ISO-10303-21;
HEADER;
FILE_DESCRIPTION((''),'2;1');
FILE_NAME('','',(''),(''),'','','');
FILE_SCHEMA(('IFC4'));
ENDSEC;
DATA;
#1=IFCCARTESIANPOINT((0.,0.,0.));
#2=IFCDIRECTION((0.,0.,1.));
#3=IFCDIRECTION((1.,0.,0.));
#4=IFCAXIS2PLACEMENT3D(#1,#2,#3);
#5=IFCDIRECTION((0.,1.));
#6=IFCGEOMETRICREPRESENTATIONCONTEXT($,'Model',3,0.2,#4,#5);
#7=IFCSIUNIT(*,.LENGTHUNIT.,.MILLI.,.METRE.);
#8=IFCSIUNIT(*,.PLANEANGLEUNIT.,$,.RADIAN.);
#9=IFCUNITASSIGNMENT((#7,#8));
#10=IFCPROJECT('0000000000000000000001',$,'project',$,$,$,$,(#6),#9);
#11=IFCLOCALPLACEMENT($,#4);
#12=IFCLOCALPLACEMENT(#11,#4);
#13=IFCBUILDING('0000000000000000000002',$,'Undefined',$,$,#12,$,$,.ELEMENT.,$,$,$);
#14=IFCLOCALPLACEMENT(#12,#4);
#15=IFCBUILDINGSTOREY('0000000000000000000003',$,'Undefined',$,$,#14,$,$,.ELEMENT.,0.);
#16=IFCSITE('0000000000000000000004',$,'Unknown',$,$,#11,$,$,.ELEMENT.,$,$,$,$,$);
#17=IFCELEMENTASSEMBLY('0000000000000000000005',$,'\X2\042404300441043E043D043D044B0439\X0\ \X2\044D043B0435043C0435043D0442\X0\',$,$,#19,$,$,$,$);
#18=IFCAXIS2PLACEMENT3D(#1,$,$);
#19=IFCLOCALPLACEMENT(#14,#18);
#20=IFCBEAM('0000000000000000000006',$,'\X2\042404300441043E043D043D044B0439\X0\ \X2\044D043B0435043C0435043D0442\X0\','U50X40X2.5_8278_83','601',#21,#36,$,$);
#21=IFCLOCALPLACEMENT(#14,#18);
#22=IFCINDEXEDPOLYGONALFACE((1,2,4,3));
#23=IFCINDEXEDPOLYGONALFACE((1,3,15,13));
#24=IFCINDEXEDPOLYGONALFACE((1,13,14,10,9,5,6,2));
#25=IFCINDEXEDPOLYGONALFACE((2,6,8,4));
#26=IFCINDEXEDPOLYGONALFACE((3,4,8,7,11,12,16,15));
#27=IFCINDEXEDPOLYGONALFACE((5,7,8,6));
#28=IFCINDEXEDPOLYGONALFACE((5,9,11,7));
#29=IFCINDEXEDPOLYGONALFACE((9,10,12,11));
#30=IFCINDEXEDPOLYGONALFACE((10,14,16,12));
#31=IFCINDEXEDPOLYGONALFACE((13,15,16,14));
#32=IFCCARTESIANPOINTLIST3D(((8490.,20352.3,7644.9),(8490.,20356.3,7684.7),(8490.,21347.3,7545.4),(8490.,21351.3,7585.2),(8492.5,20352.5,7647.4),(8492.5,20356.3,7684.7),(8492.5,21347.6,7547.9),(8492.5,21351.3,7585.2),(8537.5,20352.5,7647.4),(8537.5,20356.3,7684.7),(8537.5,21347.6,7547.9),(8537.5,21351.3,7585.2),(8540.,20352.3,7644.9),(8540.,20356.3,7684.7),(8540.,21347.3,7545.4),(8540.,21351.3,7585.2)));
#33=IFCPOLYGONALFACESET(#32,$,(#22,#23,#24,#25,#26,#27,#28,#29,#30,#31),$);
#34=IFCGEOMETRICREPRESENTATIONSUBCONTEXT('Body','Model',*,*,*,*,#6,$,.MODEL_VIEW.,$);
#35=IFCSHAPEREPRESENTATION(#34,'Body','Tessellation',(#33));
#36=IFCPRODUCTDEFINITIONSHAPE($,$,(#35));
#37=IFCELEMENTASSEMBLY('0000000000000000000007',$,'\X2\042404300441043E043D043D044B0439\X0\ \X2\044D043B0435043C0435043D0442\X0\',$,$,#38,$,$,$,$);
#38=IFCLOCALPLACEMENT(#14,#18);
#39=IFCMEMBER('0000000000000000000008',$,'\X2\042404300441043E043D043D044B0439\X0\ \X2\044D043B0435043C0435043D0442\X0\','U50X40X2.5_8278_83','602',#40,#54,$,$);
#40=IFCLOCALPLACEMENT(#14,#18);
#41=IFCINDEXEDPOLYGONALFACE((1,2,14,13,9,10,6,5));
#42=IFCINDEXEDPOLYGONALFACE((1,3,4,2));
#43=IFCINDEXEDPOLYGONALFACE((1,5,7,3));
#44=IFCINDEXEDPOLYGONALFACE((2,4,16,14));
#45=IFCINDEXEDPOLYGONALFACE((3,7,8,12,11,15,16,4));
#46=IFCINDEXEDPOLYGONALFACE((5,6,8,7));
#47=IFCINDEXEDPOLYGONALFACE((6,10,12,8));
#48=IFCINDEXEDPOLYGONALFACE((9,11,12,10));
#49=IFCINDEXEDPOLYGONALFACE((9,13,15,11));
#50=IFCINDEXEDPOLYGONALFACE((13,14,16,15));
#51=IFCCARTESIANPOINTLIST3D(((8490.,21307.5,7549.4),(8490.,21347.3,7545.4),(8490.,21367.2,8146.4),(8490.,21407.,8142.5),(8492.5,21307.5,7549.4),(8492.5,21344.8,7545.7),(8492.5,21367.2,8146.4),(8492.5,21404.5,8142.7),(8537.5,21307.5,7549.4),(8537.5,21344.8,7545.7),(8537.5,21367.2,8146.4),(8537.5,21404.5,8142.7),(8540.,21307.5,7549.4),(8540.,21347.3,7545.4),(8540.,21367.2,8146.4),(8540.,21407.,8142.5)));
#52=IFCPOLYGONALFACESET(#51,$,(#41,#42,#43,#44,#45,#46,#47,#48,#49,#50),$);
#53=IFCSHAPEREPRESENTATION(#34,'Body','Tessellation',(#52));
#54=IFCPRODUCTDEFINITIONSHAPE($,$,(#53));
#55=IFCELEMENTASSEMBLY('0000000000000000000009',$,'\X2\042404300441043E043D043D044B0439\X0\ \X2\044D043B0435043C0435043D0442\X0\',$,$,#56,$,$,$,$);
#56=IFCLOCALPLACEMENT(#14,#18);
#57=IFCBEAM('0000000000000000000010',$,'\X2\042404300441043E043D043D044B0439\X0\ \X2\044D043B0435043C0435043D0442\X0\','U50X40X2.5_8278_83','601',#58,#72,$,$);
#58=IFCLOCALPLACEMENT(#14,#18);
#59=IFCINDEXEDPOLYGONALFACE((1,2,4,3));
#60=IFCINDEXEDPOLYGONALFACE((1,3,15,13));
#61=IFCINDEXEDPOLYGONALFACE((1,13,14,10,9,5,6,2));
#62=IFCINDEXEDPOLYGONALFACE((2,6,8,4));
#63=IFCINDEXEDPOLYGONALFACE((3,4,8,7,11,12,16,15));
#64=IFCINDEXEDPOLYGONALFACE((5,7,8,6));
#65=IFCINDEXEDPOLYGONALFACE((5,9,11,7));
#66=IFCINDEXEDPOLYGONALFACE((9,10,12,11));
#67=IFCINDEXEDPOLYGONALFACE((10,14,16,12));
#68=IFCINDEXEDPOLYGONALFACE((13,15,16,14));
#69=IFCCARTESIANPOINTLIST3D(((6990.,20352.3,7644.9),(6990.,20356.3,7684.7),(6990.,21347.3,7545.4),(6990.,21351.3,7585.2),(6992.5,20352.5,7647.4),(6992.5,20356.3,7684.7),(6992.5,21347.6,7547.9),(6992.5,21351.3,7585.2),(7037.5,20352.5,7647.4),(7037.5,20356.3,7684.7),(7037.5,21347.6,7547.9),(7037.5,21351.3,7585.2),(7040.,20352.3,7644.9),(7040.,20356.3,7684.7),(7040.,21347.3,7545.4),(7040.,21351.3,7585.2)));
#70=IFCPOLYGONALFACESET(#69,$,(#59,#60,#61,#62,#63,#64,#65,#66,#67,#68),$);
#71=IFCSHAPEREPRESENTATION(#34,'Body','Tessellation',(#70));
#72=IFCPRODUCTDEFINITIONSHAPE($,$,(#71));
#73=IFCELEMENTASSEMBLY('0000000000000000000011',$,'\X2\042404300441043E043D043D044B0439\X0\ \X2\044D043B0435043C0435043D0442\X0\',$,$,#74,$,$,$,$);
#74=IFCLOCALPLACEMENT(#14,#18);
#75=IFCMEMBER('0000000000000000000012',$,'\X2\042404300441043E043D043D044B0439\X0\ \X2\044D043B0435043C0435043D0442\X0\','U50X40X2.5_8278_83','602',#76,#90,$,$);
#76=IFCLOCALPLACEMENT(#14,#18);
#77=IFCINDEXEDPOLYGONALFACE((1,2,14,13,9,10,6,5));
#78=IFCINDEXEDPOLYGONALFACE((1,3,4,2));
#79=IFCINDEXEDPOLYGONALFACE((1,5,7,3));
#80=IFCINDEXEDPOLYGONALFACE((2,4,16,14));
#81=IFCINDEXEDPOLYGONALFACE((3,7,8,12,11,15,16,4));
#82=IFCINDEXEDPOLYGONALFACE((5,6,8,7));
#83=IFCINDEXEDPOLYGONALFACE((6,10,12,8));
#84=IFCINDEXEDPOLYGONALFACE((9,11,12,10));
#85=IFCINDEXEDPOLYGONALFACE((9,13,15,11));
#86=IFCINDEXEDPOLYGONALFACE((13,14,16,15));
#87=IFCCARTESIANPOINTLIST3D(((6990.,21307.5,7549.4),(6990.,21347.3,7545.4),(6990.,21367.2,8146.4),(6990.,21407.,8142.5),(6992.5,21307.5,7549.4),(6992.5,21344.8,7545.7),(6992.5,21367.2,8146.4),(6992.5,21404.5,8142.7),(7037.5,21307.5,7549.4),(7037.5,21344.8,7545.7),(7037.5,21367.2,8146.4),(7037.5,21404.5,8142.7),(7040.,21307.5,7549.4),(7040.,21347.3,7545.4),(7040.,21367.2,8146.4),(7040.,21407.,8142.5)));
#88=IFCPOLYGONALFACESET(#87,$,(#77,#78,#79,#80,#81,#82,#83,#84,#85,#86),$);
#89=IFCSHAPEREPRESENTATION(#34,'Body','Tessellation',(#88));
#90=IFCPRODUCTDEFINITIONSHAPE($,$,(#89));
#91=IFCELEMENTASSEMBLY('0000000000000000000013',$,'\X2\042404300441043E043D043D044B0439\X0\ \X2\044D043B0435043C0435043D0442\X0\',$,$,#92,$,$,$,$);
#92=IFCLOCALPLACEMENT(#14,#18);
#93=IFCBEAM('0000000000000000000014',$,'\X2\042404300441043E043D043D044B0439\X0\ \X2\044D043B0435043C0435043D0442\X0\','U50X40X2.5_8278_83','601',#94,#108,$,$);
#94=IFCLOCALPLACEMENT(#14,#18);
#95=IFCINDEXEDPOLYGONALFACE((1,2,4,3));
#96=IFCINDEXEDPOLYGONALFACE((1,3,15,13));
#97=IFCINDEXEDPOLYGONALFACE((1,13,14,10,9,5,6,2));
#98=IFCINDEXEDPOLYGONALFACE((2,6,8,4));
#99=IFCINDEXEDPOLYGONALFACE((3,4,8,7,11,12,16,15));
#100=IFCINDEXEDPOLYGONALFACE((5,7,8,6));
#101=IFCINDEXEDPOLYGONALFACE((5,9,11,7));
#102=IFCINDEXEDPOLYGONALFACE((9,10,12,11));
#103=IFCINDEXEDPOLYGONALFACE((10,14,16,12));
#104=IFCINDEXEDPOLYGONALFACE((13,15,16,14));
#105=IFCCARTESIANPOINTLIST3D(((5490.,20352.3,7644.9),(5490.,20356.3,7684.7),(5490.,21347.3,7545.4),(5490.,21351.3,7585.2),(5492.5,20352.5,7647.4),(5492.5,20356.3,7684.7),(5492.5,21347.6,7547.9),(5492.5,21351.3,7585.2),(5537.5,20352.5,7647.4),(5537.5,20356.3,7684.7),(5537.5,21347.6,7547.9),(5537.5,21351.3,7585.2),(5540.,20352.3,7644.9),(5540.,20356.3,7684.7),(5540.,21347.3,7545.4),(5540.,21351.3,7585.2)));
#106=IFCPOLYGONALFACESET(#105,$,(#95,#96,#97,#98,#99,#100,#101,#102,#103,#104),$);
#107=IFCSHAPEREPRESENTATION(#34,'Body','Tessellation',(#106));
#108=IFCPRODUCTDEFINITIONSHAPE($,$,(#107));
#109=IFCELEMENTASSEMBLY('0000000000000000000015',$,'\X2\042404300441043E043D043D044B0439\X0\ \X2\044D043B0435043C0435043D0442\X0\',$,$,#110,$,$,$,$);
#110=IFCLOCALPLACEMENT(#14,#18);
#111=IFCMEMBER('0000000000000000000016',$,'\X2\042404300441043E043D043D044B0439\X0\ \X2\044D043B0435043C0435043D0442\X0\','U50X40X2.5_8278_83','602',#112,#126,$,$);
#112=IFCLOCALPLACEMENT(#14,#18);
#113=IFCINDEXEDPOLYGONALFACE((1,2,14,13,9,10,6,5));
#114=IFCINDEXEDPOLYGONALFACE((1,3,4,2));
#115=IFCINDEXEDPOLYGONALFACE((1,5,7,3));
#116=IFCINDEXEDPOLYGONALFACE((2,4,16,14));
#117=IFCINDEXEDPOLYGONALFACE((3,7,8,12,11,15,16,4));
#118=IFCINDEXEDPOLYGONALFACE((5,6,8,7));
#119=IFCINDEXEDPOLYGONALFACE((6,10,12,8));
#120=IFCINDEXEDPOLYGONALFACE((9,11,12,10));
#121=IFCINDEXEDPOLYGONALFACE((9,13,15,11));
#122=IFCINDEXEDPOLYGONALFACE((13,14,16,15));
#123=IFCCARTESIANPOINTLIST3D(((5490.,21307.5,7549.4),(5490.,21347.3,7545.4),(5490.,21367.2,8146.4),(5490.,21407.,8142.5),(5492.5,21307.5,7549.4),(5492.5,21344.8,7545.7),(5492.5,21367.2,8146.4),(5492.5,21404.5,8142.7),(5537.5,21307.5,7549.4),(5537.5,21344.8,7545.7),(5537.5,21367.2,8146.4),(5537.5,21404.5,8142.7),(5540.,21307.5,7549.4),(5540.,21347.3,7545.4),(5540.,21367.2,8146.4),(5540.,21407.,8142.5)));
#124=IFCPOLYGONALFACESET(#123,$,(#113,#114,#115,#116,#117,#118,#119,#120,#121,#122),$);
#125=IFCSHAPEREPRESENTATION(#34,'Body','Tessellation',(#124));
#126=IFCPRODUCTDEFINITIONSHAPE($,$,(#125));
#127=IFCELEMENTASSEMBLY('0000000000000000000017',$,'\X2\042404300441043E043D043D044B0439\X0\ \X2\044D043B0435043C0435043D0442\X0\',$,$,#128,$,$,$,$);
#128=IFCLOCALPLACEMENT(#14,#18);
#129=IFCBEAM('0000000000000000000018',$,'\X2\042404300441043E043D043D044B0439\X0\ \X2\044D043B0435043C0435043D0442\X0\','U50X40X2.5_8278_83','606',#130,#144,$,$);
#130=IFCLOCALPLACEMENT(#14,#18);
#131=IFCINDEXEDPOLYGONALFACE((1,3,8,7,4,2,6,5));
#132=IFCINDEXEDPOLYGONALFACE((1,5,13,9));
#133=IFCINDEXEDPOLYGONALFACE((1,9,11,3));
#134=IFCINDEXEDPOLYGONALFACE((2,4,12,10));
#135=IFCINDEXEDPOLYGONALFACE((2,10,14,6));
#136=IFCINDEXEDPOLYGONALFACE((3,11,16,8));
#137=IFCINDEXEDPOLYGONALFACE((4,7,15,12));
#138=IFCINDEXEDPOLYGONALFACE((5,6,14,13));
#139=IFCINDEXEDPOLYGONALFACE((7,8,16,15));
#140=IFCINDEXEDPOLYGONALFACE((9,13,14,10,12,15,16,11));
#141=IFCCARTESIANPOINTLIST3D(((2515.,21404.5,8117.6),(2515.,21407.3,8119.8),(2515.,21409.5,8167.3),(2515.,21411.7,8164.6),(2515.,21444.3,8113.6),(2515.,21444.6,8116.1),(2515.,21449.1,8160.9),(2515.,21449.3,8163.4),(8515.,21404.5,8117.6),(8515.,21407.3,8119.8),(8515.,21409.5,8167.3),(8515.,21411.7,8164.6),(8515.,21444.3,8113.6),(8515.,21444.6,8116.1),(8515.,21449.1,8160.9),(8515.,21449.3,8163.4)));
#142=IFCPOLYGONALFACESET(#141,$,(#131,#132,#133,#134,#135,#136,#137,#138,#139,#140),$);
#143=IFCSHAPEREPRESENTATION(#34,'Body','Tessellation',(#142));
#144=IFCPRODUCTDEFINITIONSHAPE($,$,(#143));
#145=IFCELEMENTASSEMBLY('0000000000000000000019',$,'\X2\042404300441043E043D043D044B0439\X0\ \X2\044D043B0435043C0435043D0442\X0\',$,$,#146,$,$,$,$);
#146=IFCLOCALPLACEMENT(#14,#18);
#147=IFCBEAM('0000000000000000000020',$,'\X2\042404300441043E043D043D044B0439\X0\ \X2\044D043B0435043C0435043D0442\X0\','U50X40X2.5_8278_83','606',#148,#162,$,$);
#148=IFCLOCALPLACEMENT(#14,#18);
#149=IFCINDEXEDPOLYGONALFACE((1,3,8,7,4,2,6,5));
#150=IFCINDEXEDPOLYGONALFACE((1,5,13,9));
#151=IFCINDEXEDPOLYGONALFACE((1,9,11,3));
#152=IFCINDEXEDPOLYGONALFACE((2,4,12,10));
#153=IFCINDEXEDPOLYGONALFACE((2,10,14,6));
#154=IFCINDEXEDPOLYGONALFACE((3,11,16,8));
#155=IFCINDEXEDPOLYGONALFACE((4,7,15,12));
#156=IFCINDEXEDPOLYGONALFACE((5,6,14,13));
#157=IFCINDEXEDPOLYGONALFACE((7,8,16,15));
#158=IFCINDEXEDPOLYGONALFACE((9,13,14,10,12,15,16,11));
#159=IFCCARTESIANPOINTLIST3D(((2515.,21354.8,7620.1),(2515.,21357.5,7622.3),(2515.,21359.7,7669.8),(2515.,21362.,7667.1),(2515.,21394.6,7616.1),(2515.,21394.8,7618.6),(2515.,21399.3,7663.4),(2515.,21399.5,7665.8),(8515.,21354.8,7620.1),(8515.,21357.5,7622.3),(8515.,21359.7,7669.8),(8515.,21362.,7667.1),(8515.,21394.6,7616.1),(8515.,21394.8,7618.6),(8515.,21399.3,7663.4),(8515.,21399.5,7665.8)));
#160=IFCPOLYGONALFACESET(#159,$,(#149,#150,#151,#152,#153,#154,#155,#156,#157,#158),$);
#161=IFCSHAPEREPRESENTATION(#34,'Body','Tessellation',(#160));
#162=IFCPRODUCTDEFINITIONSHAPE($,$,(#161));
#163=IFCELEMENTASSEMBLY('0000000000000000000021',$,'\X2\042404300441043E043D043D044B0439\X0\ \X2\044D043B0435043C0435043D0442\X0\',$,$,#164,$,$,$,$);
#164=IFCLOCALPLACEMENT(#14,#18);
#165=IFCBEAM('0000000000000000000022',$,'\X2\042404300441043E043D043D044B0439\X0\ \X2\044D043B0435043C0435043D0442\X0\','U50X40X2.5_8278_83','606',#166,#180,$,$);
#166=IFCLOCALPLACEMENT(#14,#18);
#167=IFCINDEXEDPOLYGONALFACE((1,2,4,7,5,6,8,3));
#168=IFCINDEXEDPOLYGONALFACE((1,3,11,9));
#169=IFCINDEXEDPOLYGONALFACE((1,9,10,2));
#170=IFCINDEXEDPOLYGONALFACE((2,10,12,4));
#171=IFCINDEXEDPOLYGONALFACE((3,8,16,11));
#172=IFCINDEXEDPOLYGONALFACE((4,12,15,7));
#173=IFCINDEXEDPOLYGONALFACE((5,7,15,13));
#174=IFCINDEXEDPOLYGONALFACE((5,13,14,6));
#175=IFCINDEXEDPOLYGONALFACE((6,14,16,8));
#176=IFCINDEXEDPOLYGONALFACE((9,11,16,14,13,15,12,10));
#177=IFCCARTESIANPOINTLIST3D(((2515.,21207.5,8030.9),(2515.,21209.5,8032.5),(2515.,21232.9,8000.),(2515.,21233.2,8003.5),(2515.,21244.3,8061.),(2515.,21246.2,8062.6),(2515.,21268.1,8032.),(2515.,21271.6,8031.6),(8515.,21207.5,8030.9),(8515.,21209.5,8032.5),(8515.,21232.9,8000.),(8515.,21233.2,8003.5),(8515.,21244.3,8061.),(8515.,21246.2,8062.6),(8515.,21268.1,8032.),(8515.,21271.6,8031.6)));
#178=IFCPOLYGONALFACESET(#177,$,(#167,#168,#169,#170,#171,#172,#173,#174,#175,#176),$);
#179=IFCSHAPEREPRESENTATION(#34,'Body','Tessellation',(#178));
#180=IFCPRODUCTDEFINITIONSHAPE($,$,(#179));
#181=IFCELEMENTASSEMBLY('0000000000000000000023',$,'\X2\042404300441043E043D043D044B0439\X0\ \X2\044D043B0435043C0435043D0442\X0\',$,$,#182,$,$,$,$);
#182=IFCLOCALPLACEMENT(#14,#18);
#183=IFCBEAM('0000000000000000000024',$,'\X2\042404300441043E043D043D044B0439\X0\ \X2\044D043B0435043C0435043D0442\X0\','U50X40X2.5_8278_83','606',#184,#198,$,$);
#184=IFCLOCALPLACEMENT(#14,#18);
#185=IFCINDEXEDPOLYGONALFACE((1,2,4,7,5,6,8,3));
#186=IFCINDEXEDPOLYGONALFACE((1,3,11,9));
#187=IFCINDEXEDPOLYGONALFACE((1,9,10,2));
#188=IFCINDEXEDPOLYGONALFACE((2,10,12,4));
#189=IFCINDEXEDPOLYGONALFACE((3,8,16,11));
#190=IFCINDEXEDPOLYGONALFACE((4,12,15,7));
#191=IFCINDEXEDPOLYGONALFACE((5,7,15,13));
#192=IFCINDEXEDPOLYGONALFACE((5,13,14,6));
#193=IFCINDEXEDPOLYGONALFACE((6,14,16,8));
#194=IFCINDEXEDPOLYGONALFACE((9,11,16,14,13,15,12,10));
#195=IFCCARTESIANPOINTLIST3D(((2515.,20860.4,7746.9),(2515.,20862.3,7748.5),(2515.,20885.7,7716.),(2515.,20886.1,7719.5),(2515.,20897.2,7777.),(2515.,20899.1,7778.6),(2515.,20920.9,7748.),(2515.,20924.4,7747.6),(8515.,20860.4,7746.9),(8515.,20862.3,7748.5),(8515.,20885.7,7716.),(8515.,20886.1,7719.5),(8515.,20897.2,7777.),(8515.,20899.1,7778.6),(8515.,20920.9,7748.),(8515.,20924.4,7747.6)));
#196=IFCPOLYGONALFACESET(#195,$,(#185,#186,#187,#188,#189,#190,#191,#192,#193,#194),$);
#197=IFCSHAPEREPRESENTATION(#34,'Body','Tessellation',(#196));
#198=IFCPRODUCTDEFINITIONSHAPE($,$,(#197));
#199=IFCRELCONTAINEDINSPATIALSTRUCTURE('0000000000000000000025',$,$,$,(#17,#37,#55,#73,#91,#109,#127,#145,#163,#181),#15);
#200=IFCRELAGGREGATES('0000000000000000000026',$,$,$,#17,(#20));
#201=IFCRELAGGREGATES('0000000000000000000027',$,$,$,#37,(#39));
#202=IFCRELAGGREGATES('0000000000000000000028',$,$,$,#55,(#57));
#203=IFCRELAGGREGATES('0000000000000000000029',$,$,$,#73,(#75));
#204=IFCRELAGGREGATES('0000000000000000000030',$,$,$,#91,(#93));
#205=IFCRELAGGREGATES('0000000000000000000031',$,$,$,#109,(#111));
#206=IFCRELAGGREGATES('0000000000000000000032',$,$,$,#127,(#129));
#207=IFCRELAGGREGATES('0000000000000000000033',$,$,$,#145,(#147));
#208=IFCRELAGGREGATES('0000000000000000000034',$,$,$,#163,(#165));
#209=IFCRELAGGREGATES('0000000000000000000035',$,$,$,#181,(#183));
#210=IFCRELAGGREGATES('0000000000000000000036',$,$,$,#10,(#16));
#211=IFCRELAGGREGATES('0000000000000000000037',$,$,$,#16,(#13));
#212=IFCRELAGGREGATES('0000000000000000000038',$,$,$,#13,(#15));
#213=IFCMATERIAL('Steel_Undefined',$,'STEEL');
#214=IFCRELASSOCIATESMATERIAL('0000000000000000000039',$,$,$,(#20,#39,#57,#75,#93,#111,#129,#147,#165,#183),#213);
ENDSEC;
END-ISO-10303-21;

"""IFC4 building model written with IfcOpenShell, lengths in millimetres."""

from ifc_helpers import new_model, si_unit, direction, frame, origin_with_axes, place, context, subcontext, project, spatial, line, indexed_curve, outline, extrude, material, element, aggregate, save


model = new_model("IFC4")

# Units and contexts
model_context = context("Model", 3, precision=0.2, world=origin_with_axes(), true_north=direction((0.0, 1.0)))
body_context = subcontext(model_context, "Body", "Model", "MODEL_VIEW")
ifc_project = project(units=[si_unit("LENGTHUNIT", "METRE", prefix="MILLI"), si_unit("PLANEANGLEUNIT", "RADIAN")], contexts=[model_context])

# Site, building, storey
site_placement = place(None, origin_with_axes())
site = spatial("IfcSite", under=ifc_project, at=site_placement, Name="Unknown", CompositionType="ELEMENT")
building_placement = place(site_placement, origin_with_axes())
building = spatial("IfcBuilding", under=site, at=building_placement, Name="Undefined", CompositionType="ELEMENT")
storey_placement = place(building_placement, origin_with_axes())
storey = spatial("IfcBuildingStorey", under=building, at=storey_placement, Name="Undefined", CompositionType="ELEMENT", Elevation=0.0)

# Element assembly, beam
assembly_1_placement = place(storey_placement, frame((8515.0, 21349.3, 7565.3), z_axis=(0.0, 0.099504, 0.995037), x_axis=(0.0, -0.995037, 0.099504)))
assembly_1 = element("IfcElementAssembly", 1, at=assembly_1_placement, inside=storey, Name="Фасонный элемент")
ifc_material_1 = material(Name="Steel_Undefined", Category="STEEL")
beam_1_placement = place(assembly_1_placement, origin_with_axes())
beam_1 = element("IfcBeam", 2, at=beam_1_placement, material=ifc_material_1, Name="Фасонный элемент", Description="U50X40X2.5_8278_83", ObjectType="601", context=body_context, shape_type="SolidModel", body=[
    extrude(outline(indexed_curve([(-20.0, -25.0), (20.0, -25.0), (20.0, -22.5), (-17.5, -22.5), (-17.5, 22.5), (20.0, 22.5), (20.0, 25.0), (-20.0, 25.0)], segments=[line(1, 2, 3, 4, 5, 6, 7, 8, 1)])), frame((0.0, 0.0, 0.0), z_axis=(-1.0, 0.0, 0.0), x_axis=(0.0, 0.0, 1.0)), (0.0, 0.0, -1.0), 1000.0),
])
aggregate(assembly_1, [beam_1])

# Element assembly, member
assembly_2_placement = place(storey_placement, frame((8515.0, 21327.4, 7547.4), z_axis=(0.0, -0.995037, 0.099504), x_axis=(0.0, 0.099504, 0.995037)))
assembly_2 = element("IfcElementAssembly", 3, at=assembly_2_placement, inside=storey, Name="Фасонный элемент")
member_1_placement = place(assembly_2_placement, origin_with_axes())
member_1 = element("IfcMember", 4, at=member_1_placement, material=ifc_material_1, Name="Фасонный элемент", Description="U50X40X2.5_8278_83", ObjectType="602", context=body_context, shape_type="SolidModel", body=[
    extrude(outline(indexed_curve([(-20.0, -25.0), (20.0, -25.0), (20.0, -22.5), (-17.5, -22.5), (-17.5, 22.5), (20.0, 22.5), (20.0, 25.0), (-20.0, 25.0)], segments=[line(1, 2, 3, 4, 5, 6, 7, 8, 1)])), frame((0.0, 0.0, 0.0), z_axis=(-1.0, 0.0, 0.0), x_axis=(0.0, 0.0, 1.0)), (0.0, 0.0, -1.0), 600.0),
])
aggregate(assembly_2, [member_1])

# Element assembly, beam
assembly_3_placement = place(storey_placement, frame((7015.0, 21349.3, 7565.3), z_axis=(0.0, 0.099504, 0.995037), x_axis=(0.0, -0.995037, 0.099504)))
assembly_3 = element("IfcElementAssembly", 5, at=assembly_3_placement, inside=storey, Name="Фасонный элемент")
beam_2_placement = place(assembly_3_placement, origin_with_axes())
beam_2 = element("IfcBeam", 6, at=beam_2_placement, material=ifc_material_1, Name="Фасонный элемент", Description="U50X40X2.5_8278_83", ObjectType="601", context=body_context, shape_type="SolidModel", body=[
    extrude(outline(indexed_curve([(-20.0, -25.0), (20.0, -25.0), (20.0, -22.5), (-17.5, -22.5), (-17.5, 22.5), (20.0, 22.5), (20.0, 25.0), (-20.0, 25.0)], segments=[line(1, 2, 3, 4, 5, 6, 7, 8, 1)])), frame((0.0, 0.0, 0.0), z_axis=(-1.0, 0.0, 0.0), x_axis=(0.0, 0.0, 1.0)), (0.0, 0.0, -1.0), 1000.0),
])
aggregate(assembly_3, [beam_2])

# Element assembly, member
assembly_4_placement = place(storey_placement, frame((7015.0, 21327.4, 7547.4), z_axis=(0.0, -0.995037, 0.099504), x_axis=(0.0, 0.099504, 0.995037)))
assembly_4 = element("IfcElementAssembly", 7, at=assembly_4_placement, inside=storey, Name="Фасонный элемент")
member_2_placement = place(assembly_4_placement, origin_with_axes())
member_2 = element("IfcMember", 8, at=member_2_placement, material=ifc_material_1, Name="Фасонный элемент", Description="U50X40X2.5_8278_83", ObjectType="602", context=body_context, shape_type="SolidModel", body=[
    extrude(outline(indexed_curve([(-20.0, -25.0), (20.0, -25.0), (20.0, -22.5), (-17.5, -22.5), (-17.5, 22.5), (20.0, 22.5), (20.0, 25.0), (-20.0, 25.0)], segments=[line(1, 2, 3, 4, 5, 6, 7, 8, 1)])), frame((0.0, 0.0, 0.0), z_axis=(-1.0, 0.0, 0.0), x_axis=(0.0, 0.0, 1.0)), (0.0, 0.0, -1.0), 600.0),
])
aggregate(assembly_4, [member_2])

# Element assembly, beam
assembly_5_placement = place(storey_placement, frame((5515.0, 21349.3, 7565.3), z_axis=(0.0, 0.099504, 0.995037), x_axis=(0.0, -0.995037, 0.099504)))
assembly_5 = element("IfcElementAssembly", 9, at=assembly_5_placement, inside=storey, Name="Фасонный элемент")
beam_3_placement = place(assembly_5_placement, origin_with_axes())
beam_3 = element("IfcBeam", 10, at=beam_3_placement, material=ifc_material_1, Name="Фасонный элемент", Description="U50X40X2.5_8278_83", ObjectType="601", context=body_context, shape_type="SolidModel", body=[
    extrude(outline(indexed_curve([(-20.0, -25.0), (20.0, -25.0), (20.0, -22.5), (-17.5, -22.5), (-17.5, 22.5), (20.0, 22.5), (20.0, 25.0), (-20.0, 25.0)], segments=[line(1, 2, 3, 4, 5, 6, 7, 8, 1)])), frame((0.0, 0.0, 0.0), z_axis=(-1.0, 0.0, 0.0), x_axis=(0.0, 0.0, 1.0)), (0.0, 0.0, -1.0), 1000.0),
])
aggregate(assembly_5, [beam_3])

# Element assembly, member
assembly_6_placement = place(storey_placement, frame((5515.0, 21327.4, 7547.4), z_axis=(0.0, -0.995037, 0.099504), x_axis=(0.0, 0.099504, 0.995037)))
assembly_6 = element("IfcElementAssembly", 11, at=assembly_6_placement, inside=storey, Name="Фасонный элемент")
member_3_placement = place(assembly_6_placement, origin_with_axes())
member_3 = element("IfcMember", 12, at=member_3_placement, material=ifc_material_1, Name="Фасонный элемент", Description="U50X40X2.5_8278_83", ObjectType="602", context=body_context, shape_type="SolidModel", body=[
    extrude(outline(indexed_curve([(-20.0, -25.0), (20.0, -25.0), (20.0, -22.5), (-17.5, -22.5), (-17.5, 22.5), (20.0, 22.5), (20.0, 25.0), (-20.0, 25.0)], segments=[line(1, 2, 3, 4, 5, 6, 7, 8, 1)])), frame((0.0, 0.0, 0.0), z_axis=(-1.0, 0.0, 0.0), x_axis=(0.0, 0.0, 1.0)), (0.0, 0.0, -1.0), 600.0),
])
aggregate(assembly_6, [member_3])

# Element assemblies, beams
assembly_7_placement = place(storey_placement, frame((8515.0, 21426.9, 8140.5), z_axis=(0.0, 0.995037, -0.099504), x_axis=(-1.0, 0.0, 0.0)))
assembly_7 = element("IfcElementAssembly", 13, at=assembly_7_placement, inside=storey, Name="Фасонный элемент")
beam_4_placement = place(assembly_7_placement, origin_with_axes())
beam_4 = element("IfcBeam", 14, at=beam_4_placement, material=ifc_material_1, Name="Фасонный элемент", Description="U50X40X2.5_8278_83", ObjectType="606", context=body_context, shape_type="SolidModel", body=[
    extrude(outline(indexed_curve([(-20.0, -25.0), (20.0, -25.0), (20.0, -22.5), (-17.5, -22.5), (-17.5, 22.5), (20.0, 22.5), (20.0, 25.0), (-20.0, 25.0)], segments=[line(1, 2, 3, 4, 5, 6, 7, 8, 1)])), frame((0.0, 0.0, 0.0), z_axis=(-1.0, 0.0, 0.0), x_axis=(0.0, 0.0, 1.0)), (0.0, 0.0, -1.0), 6000.0),
])
aggregate(assembly_7, [beam_4])
assembly_8_placement = place(storey_placement, frame((8515.0, 21377.2, 7643.0), z_axis=(0.0, 0.995037, -0.099504), x_axis=(-1.0, 0.0, 0.0)))
assembly_8 = element("IfcElementAssembly", 15, at=assembly_8_placement, inside=storey, Name="Фасонный элемент")
beam_5_placement = place(assembly_8_placement, origin_with_axes())
beam_5 = element("IfcBeam", 16, at=beam_5_placement, material=ifc_material_1, Name="Фасонный элемент", Description="U50X40X2.5_8278_83", ObjectType="606", context=body_context, shape_type="SolidModel", body=[
    extrude(outline(indexed_curve([(-20.0, -25.0), (20.0, -25.0), (20.0, -22.5), (-17.5, -22.5), (-17.5, 22.5), (20.0, 22.5), (20.0, 25.0), (-20.0, 25.0)], segments=[line(1, 2, 3, 4, 5, 6, 7, 8, 1)])), frame((0.0, 0.0, 0.0), z_axis=(-1.0, 0.0, 0.0), x_axis=(0.0, 0.0, 1.0)), (0.0, 0.0, -1.0), 6000.0),
])
aggregate(assembly_8, [beam_5])
assembly_9_placement = place(storey_placement, frame((8515.0, 21239.6, 8031.3), z_axis=(0.0, -0.633238, 0.773957), x_axis=(-1.0, 0.0, 0.0)))
assembly_9 = element("IfcElementAssembly", 17, at=assembly_9_placement, inside=storey, Name="Фасонный элемент")
beam_6_placement = place(assembly_9_placement, origin_with_axes())
beam_6 = element("IfcBeam", 18, at=beam_6_placement, material=ifc_material_1, Name="Фасонный элемент", Description="U50X40X2.5_8278_83", ObjectType="606", context=body_context, shape_type="SolidModel", body=[
    extrude(outline(indexed_curve([(-20.0, -25.0), (20.0, -25.0), (20.0, -22.5), (-17.5, -22.5), (-17.5, 22.5), (20.0, 22.5), (20.0, 25.0), (-20.0, 25.0)], segments=[line(1, 2, 3, 4, 5, 6, 7, 8, 1)])), frame((0.0, 0.0, 0.0), z_axis=(-1.0, 0.0, 0.0), x_axis=(0.0, 0.0, 1.0)), (0.0, 0.0, -1.0), 6000.0),
])
aggregate(assembly_9, [beam_6])
assembly_10_placement = place(storey_placement, frame((8515.0, 20892.4, 7747.3), z_axis=(0.0, -0.633238, 0.773957), x_axis=(-1.0, 0.0, 0.0)))
assembly_10 = element("IfcElementAssembly", 19, at=assembly_10_placement, inside=storey, Name="Фасонный элемент")
beam_7_placement = place(assembly_10_placement, origin_with_axes())
beam_7 = element("IfcBeam", 20, at=beam_7_placement, material=ifc_material_1, Name="Фасонный элемент", Description="U50X40X2.5_8278_83", ObjectType="606", context=body_context, shape_type="SolidModel", body=[
    extrude(outline(indexed_curve([(-20.0, -25.0), (20.0, -25.0), (20.0, -22.5), (-17.5, -22.5), (-17.5, 22.5), (20.0, 22.5), (20.0, 25.0), (-20.0, 25.0)], segments=[line(1, 2, 3, 4, 5, 6, 7, 8, 1)])), frame((0.0, 0.0, 0.0), z_axis=(-1.0, 0.0, 0.0), x_axis=(0.0, 0.0, 1.0)), (0.0, 0.0, -1.0), 6000.0),
])
aggregate(assembly_10, [beam_7])

save(model, "model.ifc")
